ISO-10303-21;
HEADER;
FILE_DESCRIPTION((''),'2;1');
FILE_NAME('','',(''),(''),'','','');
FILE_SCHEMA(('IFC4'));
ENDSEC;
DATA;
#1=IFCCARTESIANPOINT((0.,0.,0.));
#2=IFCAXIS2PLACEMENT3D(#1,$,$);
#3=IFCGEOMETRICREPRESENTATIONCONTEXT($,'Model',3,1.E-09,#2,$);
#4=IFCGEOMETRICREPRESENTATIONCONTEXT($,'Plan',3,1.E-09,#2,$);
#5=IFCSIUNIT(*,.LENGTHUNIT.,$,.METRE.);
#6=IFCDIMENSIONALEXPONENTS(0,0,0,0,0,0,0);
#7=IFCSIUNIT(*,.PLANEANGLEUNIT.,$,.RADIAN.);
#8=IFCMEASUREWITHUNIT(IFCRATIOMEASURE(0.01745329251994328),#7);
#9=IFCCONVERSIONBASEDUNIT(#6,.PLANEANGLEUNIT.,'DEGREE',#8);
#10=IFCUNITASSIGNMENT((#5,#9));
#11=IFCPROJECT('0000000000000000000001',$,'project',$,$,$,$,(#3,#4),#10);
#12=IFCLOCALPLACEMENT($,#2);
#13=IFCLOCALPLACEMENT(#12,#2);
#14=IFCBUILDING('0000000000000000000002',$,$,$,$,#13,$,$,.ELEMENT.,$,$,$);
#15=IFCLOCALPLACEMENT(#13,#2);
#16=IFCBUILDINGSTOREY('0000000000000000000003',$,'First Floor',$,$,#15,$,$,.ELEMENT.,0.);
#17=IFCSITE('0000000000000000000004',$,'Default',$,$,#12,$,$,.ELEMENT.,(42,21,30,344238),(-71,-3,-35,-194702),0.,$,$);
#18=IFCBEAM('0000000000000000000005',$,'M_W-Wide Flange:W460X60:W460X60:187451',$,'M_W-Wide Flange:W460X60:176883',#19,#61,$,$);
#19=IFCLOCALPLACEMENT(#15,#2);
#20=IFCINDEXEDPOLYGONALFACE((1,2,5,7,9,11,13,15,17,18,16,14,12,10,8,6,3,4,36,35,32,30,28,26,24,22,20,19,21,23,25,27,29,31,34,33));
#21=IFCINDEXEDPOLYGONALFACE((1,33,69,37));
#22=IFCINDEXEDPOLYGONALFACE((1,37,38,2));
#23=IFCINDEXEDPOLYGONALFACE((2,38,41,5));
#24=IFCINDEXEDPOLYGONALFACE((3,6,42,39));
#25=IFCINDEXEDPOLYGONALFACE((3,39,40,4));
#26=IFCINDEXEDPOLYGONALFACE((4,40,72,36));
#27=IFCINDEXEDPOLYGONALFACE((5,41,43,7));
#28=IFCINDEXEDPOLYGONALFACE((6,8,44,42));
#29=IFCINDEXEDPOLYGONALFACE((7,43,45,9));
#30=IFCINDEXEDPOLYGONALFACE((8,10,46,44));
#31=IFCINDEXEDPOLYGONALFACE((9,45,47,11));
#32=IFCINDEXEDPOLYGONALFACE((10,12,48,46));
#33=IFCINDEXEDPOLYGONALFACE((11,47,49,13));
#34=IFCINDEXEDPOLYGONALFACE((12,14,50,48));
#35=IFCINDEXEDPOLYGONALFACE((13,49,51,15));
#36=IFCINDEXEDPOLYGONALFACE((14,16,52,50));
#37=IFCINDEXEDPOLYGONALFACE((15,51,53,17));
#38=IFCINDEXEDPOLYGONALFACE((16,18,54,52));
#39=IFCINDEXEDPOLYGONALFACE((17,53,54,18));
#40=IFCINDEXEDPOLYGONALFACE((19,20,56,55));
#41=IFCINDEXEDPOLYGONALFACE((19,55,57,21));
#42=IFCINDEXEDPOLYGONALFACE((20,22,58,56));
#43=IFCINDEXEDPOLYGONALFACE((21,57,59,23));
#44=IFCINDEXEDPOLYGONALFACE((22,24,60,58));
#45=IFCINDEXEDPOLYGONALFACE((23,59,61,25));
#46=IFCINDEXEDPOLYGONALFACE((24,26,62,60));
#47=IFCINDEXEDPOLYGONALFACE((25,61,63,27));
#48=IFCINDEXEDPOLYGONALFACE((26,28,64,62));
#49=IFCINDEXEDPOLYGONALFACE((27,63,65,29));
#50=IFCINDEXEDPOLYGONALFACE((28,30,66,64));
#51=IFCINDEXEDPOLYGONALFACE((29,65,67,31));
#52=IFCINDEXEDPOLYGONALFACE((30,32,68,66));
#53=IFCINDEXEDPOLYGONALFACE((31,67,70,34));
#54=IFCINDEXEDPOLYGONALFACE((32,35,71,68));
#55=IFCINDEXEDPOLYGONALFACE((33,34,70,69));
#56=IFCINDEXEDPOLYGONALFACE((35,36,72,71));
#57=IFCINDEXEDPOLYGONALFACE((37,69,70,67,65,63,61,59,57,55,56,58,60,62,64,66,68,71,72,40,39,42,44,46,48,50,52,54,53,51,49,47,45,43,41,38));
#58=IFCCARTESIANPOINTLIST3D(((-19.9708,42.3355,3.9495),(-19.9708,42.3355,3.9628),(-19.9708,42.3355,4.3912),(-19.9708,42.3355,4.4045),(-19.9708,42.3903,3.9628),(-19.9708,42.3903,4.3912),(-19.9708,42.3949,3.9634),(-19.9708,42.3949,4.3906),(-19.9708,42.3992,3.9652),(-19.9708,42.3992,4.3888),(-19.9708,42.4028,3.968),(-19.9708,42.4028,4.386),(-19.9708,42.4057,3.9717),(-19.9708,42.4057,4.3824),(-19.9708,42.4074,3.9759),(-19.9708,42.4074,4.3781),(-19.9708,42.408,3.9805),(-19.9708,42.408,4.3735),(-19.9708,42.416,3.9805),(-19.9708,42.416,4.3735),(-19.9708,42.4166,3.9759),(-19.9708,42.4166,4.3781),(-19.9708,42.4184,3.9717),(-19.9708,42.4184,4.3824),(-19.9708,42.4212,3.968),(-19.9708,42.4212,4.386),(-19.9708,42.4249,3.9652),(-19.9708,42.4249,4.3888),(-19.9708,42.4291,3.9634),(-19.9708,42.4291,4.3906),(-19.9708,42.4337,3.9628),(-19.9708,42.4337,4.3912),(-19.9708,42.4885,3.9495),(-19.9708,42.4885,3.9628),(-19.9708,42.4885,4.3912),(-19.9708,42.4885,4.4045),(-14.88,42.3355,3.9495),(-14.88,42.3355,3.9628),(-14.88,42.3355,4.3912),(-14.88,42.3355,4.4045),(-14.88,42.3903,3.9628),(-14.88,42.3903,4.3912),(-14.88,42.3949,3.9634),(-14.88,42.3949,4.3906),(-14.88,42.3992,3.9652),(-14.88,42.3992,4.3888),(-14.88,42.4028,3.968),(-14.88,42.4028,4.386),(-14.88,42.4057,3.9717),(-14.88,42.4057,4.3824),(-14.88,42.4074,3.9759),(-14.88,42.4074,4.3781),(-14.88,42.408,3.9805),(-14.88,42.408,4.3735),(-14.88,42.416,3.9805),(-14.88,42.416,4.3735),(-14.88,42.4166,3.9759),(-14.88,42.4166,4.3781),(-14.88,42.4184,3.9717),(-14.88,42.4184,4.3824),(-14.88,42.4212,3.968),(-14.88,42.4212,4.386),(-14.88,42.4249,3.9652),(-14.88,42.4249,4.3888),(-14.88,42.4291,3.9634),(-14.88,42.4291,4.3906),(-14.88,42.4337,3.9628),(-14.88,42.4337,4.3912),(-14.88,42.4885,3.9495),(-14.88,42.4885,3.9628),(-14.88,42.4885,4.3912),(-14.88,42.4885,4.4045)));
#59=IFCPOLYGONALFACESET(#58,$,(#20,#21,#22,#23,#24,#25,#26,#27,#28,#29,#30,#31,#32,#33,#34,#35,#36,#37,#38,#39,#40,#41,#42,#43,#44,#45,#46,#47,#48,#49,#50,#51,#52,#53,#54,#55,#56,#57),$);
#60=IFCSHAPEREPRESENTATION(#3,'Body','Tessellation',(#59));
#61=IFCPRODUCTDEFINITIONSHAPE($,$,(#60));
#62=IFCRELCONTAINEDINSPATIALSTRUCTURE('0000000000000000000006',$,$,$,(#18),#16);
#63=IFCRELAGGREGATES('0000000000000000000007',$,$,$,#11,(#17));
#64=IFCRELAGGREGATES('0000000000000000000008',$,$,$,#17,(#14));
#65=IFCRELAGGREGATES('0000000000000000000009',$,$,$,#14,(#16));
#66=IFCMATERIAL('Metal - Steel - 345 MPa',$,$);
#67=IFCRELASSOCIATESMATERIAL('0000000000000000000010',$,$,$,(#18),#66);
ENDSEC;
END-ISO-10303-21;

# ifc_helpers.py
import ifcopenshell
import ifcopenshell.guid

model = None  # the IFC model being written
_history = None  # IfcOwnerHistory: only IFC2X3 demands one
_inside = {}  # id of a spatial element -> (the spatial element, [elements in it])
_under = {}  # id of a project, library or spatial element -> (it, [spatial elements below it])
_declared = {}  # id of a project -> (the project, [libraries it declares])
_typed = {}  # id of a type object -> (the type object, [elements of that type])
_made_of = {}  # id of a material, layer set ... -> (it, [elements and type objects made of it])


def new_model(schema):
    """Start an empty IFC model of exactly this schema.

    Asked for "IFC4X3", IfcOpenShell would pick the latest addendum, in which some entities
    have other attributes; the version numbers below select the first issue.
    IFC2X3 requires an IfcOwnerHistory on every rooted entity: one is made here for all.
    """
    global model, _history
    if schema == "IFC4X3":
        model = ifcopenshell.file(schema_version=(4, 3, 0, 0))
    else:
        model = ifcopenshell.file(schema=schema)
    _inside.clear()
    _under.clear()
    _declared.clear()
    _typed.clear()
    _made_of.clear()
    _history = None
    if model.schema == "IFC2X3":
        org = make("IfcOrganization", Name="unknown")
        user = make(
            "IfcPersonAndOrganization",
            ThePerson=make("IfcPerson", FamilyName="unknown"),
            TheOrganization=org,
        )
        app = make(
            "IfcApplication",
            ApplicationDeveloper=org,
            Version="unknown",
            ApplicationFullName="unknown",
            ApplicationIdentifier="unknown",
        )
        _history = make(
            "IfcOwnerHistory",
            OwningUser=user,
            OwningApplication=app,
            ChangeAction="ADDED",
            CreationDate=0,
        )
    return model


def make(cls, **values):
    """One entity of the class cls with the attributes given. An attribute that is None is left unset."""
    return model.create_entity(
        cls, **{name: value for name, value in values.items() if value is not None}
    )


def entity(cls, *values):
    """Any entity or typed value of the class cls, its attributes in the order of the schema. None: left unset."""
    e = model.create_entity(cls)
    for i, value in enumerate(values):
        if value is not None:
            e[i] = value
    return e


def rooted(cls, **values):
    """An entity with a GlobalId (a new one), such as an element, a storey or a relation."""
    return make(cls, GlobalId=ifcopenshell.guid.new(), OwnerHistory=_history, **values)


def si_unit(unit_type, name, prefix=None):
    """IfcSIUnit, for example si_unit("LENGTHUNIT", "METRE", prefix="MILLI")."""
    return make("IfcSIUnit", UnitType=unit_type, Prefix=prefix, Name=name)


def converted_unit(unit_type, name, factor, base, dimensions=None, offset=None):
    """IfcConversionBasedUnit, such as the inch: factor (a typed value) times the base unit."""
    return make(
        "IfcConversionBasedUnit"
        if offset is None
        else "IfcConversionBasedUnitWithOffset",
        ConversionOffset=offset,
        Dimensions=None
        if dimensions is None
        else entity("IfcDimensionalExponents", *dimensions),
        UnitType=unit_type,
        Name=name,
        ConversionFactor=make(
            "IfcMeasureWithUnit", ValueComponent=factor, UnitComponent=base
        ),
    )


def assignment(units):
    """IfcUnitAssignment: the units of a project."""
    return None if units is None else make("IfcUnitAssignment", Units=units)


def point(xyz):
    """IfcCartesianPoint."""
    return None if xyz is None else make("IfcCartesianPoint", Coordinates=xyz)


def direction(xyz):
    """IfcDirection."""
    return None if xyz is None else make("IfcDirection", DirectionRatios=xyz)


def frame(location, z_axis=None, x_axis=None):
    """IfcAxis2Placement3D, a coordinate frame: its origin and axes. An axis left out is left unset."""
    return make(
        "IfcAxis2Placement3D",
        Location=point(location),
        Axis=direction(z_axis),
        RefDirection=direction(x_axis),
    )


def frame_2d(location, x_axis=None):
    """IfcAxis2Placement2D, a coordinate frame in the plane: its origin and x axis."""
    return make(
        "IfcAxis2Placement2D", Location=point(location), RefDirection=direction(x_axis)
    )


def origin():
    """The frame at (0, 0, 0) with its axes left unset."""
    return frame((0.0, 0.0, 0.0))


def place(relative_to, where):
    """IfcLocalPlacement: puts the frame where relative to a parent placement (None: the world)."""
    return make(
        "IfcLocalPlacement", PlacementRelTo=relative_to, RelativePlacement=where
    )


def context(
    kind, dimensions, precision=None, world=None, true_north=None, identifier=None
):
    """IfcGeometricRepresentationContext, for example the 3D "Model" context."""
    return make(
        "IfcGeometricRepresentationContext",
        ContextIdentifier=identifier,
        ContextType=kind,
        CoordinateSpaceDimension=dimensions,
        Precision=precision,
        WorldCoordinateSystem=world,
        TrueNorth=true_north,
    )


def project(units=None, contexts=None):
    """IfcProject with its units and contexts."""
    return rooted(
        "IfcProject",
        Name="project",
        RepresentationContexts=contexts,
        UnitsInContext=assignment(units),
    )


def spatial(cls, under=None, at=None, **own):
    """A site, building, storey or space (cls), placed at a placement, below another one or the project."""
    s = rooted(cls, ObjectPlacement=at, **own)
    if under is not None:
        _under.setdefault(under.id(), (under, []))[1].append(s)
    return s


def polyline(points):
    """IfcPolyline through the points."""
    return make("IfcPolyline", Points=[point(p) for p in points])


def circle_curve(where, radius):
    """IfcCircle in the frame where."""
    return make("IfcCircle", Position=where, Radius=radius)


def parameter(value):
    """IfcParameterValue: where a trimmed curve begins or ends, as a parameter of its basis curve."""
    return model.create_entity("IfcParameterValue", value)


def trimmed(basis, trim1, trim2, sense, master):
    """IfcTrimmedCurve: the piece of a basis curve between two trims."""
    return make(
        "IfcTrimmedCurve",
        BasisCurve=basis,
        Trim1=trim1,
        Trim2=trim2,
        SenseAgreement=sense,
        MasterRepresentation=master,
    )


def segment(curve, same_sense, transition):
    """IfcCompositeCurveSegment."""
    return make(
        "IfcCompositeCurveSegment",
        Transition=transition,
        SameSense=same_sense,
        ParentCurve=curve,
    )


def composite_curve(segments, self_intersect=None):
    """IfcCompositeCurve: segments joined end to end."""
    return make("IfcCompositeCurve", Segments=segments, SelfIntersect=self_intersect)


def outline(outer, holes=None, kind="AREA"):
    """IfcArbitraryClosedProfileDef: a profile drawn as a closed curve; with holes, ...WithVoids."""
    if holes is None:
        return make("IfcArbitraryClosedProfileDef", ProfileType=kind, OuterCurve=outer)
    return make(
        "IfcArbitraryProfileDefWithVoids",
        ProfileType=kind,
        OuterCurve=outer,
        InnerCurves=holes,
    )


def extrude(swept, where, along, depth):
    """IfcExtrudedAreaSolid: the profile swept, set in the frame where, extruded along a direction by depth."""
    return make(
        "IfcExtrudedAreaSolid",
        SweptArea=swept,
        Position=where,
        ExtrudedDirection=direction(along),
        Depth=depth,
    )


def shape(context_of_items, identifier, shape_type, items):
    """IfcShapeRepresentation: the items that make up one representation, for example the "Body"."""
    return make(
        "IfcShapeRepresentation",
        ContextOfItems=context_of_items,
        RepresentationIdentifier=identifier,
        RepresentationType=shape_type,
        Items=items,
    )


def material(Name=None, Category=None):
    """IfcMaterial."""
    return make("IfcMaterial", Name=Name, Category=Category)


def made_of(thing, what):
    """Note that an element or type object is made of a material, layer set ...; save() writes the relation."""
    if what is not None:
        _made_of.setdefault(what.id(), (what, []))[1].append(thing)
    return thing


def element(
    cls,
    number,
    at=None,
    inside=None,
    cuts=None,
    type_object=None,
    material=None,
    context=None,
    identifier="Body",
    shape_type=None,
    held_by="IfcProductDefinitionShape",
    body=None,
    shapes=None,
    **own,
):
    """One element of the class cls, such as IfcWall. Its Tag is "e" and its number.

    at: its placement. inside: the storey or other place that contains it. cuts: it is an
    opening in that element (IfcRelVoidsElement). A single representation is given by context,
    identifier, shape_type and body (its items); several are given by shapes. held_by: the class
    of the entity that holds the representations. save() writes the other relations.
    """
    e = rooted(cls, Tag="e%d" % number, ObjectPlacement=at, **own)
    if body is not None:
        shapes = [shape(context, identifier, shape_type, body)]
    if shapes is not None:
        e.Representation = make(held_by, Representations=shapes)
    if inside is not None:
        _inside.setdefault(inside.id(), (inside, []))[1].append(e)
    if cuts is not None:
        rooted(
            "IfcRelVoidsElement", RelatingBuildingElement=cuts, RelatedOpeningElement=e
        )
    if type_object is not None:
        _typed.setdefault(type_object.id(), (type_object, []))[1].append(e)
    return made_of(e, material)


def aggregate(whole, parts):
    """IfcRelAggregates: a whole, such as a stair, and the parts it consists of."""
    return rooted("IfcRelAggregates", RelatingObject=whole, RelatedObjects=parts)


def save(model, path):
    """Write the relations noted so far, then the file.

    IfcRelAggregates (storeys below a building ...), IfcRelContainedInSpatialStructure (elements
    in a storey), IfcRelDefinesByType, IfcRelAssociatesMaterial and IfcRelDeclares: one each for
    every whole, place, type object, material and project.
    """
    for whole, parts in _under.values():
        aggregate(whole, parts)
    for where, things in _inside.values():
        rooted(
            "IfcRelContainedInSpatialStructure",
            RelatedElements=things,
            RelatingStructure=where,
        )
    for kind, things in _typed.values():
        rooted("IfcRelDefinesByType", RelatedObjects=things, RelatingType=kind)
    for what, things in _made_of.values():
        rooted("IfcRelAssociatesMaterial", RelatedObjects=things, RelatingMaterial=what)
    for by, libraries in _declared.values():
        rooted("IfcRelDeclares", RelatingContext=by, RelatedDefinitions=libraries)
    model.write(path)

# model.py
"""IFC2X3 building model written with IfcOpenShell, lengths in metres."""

from ifc_helpers import new_model, entity, si_unit, converted_unit, frame, frame_2d, origin, place, context, project, spatial, polyline, circle_curve, parameter, trimmed, segment, composite_curve, outline, extrude, material, element, save


model = new_model("IFC2X3")

# Units and contexts
model_context = context("Model", 3, precision=1e-09, world=origin())
plan_context = context("Plan", 3, precision=1e-09, world=origin())
ifc_project = project(units=[si_unit("LENGTHUNIT", "METRE"), converted_unit("PLANEANGLEUNIT", "DEGREE", entity("IfcRatioMeasure", 0.01745329251994328), si_unit("PLANEANGLEUNIT", "RADIAN"), dimensions=[0, 0, 0, 0, 0, 0, 0])], contexts=[model_context, plan_context])

# Site, building, storey
site_placement = place(None, origin())
site = spatial("IfcSite", under=ifc_project, at=site_placement, Name="Default", CompositionType="ELEMENT", RefLatitude=(42, 21, 30, 344238), RefLongitude=(-71, -3, -35, -194702), RefElevation=0.0)
building_placement = place(site_placement, origin())
building = spatial("IfcBuilding", under=site, at=building_placement, CompositionType="ELEMENT")
storey_placement = place(building_placement, origin())
storey = spatial("IfcBuildingStorey", under=building, at=storey_placement, Name="First Floor", CompositionType="ELEMENT", Elevation=0.0)

# Shared definitions
ifc_material = material(Name="Metal - Steel - 345 MPa")

# Beam
beam_1_placement = place(storey_placement, frame((-19.9152, 42.412, 4.4045), z_axis=(0.0, 0.0, 1.0), x_axis=(0.0, -1.0, 0.0)))
element("IfcBeam", 1, at=beam_1_placement, inside=storey, material=ifc_material, Name="M_W-Wide Flange:W460X60:W460X60:187451", ObjectType="M_W-Wide Flange:W460X60:176883", context=model_context, shape_type="SweptSolid", body=[
    extrude(outline(composite_curve([segment(polyline([(-0.0765, -0.2142), (-0.0765, -0.2275)]), True, "CONTINUOUS"), segment(polyline([(-0.0765, -0.2275), (0.0765, -0.2275)]), True, "CONTINUOUS"), segment(polyline([(0.0765, -0.2275), (0.0765, -0.2142)]), True, "CONTINUOUS"), segment(polyline([(0.0765, -0.2142), (0.0217, -0.2142)]), True, "CONTINUOUS"), segment(trimmed(circle_curve(frame_2d((0.0217, -0.1965), x_axis=(1.0, 0.0)), 0.0177), [parameter(180.0)], [parameter(270.0)], True, "PARAMETER"), False, "CONTINUOUS"), segment(polyline([(0.004, -0.1965), (0.004, 0.1965)]), True, "CONTINUOUS"), segment(trimmed(circle_curve(frame_2d((0.0217, 0.1965), x_axis=(1.0, 0.0)), 0.0177), [parameter(90.0)], [parameter(180.0)], True, "PARAMETER"), False, "CONTINUOUS"), segment(polyline([(0.0217, 0.2142), (0.0765, 0.2142)]), True, "CONTINUOUS"), segment(polyline([(0.0765, 0.2142), (0.0765, 0.2275)]), True, "CONTINUOUS"), segment(polyline([(0.0765, 0.2275), (-0.0765, 0.2275)]), True, "CONTINUOUS"), segment(polyline([(-0.0765, 0.2275), (-0.0765, 0.2142)]), True, "CONTINUOUS"), segment(polyline([(-0.0765, 0.2142), (-0.0217, 0.2142)]), True, "CONTINUOUS"), segment(trimmed(circle_curve(frame_2d((-0.0217, 0.1965), x_axis=(1.0, 0.0)), 0.0177), [parameter(360.0)], [parameter(90.0)], True, "PARAMETER"), False, "CONTINUOUS"), segment(polyline([(-0.004, 0.1965), (-0.004, -0.1965)]), True, "CONTINUOUS"), segment(trimmed(circle_curve(frame_2d((-0.0217, -0.1965), x_axis=(1.0, 0.0)), 0.0177), [parameter(270.0)], [parameter(0.0)], True, "PARAMETER"), False, "CONTINUOUS"), segment(polyline([(-0.0217, -0.2142), (-0.0765, -0.2142)]), True, "CONTINUOUS")], self_intersect=False)), frame((0.0, -0.0556, -0.2275), z_axis=(0.0, -1.0, 0.0), x_axis=(1.0, 0.0, 0.0)), (0.0, 0.0, -1.0), 5.0908),
])

save(model, "model.ifc")
